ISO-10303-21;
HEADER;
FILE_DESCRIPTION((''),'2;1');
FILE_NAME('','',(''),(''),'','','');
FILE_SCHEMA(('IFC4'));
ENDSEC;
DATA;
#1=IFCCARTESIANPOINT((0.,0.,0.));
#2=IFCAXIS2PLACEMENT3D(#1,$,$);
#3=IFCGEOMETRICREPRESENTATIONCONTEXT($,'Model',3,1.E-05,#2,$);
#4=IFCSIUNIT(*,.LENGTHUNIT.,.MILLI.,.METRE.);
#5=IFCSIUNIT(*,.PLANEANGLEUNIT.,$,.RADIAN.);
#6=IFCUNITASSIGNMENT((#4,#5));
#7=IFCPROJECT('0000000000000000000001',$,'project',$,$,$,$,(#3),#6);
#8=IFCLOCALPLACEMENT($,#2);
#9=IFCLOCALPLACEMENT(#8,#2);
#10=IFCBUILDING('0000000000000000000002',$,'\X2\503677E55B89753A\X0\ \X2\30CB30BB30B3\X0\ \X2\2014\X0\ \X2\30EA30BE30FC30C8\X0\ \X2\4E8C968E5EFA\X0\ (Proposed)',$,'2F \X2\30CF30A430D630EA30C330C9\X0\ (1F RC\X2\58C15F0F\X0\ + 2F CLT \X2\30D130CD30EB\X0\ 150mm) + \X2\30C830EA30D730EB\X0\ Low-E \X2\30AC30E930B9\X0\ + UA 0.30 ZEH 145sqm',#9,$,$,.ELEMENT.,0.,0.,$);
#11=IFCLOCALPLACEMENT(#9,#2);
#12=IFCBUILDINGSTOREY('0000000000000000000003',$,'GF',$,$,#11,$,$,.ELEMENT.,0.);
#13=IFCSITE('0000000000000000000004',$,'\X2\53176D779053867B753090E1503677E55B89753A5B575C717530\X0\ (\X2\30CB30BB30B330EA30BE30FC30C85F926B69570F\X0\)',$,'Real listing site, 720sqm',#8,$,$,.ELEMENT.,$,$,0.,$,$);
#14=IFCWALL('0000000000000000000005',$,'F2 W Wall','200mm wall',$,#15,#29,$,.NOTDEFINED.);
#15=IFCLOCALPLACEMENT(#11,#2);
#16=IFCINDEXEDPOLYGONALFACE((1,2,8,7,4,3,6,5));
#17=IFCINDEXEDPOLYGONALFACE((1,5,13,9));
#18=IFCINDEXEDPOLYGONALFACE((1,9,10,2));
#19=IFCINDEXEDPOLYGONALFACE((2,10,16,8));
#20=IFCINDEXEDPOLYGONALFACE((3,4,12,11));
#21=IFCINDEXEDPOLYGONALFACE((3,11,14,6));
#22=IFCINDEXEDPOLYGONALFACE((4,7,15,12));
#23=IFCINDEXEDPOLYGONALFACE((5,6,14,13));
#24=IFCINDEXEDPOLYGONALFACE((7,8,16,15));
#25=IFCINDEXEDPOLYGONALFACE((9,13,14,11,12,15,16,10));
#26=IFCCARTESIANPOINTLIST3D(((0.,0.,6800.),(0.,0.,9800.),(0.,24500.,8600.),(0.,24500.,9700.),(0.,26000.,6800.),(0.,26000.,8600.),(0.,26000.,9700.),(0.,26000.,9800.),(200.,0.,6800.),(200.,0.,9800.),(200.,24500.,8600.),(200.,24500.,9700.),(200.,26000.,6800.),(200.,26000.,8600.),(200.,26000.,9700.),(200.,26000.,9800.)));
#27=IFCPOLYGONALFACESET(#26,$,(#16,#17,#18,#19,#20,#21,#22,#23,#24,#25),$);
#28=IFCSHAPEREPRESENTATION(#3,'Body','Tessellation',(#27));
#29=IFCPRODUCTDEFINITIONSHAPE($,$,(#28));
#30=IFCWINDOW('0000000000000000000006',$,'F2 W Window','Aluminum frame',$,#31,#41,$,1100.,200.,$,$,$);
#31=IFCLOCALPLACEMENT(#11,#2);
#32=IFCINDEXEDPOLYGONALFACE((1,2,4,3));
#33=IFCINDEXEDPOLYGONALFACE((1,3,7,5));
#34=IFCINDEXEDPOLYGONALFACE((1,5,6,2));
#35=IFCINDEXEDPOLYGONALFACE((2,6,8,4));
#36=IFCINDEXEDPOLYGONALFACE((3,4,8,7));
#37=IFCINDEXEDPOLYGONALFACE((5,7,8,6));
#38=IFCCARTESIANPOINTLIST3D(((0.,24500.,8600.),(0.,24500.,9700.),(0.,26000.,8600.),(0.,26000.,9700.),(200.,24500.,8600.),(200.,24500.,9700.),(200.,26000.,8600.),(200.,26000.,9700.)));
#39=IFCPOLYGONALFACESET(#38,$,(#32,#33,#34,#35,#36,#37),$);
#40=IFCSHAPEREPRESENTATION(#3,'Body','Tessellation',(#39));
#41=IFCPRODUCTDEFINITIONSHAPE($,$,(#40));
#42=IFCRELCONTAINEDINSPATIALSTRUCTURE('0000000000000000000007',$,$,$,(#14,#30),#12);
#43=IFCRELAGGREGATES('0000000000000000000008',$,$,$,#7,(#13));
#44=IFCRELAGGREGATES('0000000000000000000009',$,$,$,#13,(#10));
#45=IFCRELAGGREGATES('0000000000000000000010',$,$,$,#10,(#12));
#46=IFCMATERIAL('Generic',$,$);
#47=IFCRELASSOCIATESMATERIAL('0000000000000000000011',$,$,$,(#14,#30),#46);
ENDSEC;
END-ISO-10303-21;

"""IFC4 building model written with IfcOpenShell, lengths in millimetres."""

from ifc_helpers import new_model, si_unit, frame, frame_2d, origin, place, context, project, spatial, rectangle, extrude, material, element, fill, save


model = new_model("IFC4")

# Units and contexts
model_context = context("Model", 3, precision=1e-05, world=origin())
ifc_project = project(units=[si_unit("LENGTHUNIT", "METRE", prefix="MILLI"), si_unit("PLANEANGLEUNIT", "RADIAN")], contexts=[model_context])

# Site, building, storey
site_placement = place(None, origin())
site = spatial("IfcSite", under=ifc_project, at=site_placement, Name="北海道虻田郡倶知安町字山田 (ニセコリゾート徒歩圏)", ObjectType="Real listing site, 720sqm", CompositionType="ELEMENT", RefElevation=0.0)
building_placement = place(site_placement, origin())
building = spatial("IfcBuilding", under=site, at=building_placement, Name="倶知安町 ニセコ — リゾート 二階建 (Proposed)", ObjectType="2F ハイブリッド (1F RC壁式 + 2F CLT パネル 150mm) + トリプル Low-E ガラス + UA 0.30 ZEH 145sqm", CompositionType="ELEMENT", ElevationOfRefHeight=0.0, ElevationOfTerrain=0.0)
storey_placement = place(building_placement, origin())
storey = spatial("IfcBuildingStorey", under=building, at=storey_placement, Name="GF", CompositionType="ELEMENT", Elevation=0.0)

# Shared definitions
ifc_material_1 = material(Name="Generic")

# Wall, opening, window
wall_1_placement = place(storey_placement, frame((0.0, 0.0, 3400.0)))
wall_1 = element("IfcWall", 1, at=wall_1_placement, inside=storey, material=ifc_material_1, Name="F2 W Wall", Description="200mm wall", PredefinedType="NOTDEFINED", context=model_context, shape_type="SweptSolid", body=[
    extrude(rectangle(XDim=200.0, YDim=26000.0, at=frame_2d((100.0, 13000.0))), frame((0.0, 0.0, 3400.0)), (0.0, 0.0, 1.0), 3000.0),
])
opening_1_placement = place(storey_placement, frame((0.0, 12250.0, 4300.0)))
opening_1 = element("IfcOpeningElement", 2, at=opening_1_placement, cuts=wall_1, PredefinedType="NOTDEFINED", context=model_context, shape_type="SweptSolid", body=[
    extrude(rectangle(XDim=200.0, YDim=1500.0, at=frame_2d((100.0, 750.0))), frame((0.0, 12250.0, 4300.0)), (0.0, 0.0, 1.0), 1100.0),
])
window_1_placement = place(storey_placement, frame((0.0, 12250.0, 4300.0)))
window_1 = element("IfcWindow", 3, at=window_1_placement, inside=storey, material=ifc_material_1, Name="F2 W Window", Description="Aluminum frame", OverallHeight=1100.0, OverallWidth=200.0, context=model_context, shape_type="SweptSolid", body=[
    extrude(rectangle(XDim=200.0, YDim=1500.0, at=frame_2d((100.0, 750.0))), frame((0.0, 12250.0, 4300.0)), (0.0, 0.0, 1.0), 1100.0),
])
fill(opening_1, window_1)

save(model, "model.ifc")
